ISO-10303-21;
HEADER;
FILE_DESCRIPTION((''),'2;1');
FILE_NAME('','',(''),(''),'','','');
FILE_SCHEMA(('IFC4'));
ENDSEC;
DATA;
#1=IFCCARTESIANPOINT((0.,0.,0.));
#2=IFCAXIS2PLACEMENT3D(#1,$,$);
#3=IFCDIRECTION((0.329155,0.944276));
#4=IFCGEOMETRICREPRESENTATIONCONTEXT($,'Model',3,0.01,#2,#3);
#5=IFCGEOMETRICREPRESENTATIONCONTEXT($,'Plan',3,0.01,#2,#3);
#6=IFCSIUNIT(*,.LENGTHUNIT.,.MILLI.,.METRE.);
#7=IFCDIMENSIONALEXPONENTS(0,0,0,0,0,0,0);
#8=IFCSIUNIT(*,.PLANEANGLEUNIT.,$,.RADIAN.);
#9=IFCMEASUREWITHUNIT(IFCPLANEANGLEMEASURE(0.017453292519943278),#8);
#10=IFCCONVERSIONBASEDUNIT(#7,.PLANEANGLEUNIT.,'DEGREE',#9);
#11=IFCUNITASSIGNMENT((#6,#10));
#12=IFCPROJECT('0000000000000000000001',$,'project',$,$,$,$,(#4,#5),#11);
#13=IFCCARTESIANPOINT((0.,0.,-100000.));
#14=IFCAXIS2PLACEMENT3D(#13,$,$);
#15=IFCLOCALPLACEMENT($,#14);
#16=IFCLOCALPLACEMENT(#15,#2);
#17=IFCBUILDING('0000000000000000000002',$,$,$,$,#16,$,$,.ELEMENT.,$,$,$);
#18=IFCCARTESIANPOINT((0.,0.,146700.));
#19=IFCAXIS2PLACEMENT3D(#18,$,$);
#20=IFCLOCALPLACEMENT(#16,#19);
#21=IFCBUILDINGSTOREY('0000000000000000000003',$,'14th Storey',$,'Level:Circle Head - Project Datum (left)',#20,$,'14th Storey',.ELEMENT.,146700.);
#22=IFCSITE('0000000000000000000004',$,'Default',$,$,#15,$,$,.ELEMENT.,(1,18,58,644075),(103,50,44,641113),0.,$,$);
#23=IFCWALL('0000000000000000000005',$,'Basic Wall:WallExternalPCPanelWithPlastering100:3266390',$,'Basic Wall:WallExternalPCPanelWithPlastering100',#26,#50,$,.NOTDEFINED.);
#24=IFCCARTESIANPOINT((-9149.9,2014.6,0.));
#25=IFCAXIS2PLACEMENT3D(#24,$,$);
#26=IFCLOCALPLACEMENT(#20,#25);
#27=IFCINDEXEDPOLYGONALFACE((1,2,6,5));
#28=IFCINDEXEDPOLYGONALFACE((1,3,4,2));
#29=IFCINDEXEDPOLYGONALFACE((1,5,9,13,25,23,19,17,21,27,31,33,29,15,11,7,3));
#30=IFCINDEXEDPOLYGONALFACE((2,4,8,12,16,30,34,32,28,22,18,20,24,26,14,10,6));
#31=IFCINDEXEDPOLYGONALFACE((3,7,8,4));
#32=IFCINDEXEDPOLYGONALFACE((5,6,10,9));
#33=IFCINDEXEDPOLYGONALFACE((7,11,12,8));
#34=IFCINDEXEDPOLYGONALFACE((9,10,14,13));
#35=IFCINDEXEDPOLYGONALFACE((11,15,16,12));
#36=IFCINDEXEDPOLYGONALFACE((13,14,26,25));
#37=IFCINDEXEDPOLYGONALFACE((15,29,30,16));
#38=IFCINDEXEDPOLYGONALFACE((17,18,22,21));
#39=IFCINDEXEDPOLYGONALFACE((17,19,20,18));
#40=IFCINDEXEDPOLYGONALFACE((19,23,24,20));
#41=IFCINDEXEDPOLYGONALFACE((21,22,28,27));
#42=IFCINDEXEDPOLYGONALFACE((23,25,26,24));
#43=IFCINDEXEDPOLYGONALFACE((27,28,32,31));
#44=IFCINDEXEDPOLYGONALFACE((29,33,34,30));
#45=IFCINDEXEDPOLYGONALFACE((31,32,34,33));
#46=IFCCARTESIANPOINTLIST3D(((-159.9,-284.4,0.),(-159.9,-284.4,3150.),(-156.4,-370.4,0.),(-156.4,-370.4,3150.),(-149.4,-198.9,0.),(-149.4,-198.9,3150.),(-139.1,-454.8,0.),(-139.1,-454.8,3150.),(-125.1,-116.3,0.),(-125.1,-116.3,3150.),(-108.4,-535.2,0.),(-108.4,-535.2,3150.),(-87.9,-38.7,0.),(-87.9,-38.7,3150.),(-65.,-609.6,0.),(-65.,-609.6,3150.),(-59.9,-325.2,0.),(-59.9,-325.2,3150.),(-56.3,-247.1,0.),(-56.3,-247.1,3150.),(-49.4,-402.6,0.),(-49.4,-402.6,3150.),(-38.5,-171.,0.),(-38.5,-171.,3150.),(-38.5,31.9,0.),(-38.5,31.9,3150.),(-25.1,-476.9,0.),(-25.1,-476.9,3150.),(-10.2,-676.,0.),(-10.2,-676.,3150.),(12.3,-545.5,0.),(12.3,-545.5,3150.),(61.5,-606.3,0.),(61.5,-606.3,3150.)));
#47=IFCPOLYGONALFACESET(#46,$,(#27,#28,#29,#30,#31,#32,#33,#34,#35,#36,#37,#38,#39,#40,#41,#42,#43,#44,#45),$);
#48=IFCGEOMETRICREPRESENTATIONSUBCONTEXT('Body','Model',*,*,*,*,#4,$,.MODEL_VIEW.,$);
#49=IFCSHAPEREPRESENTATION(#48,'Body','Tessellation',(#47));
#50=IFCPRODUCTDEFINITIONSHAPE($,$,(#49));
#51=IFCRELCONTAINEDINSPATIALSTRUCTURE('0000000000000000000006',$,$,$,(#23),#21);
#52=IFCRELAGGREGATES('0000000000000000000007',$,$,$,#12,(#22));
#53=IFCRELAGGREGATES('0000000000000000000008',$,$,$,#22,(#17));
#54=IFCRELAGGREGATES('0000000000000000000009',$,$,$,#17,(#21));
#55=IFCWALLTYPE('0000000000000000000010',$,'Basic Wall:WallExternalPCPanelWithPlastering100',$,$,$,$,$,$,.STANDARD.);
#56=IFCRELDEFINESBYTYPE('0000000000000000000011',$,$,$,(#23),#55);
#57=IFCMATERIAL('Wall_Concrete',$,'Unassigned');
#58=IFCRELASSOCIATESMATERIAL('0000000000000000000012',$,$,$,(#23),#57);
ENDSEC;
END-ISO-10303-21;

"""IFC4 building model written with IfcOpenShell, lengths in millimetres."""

from ifc_helpers import new_model, entity, si_unit, converted_unit, direction, frame, origin, place, context, subcontext, project, spatial, line, arc, indexed_curve, outline, extrude, material, type_object, element, save


model = new_model("IFC4")

# Units and contexts
model_context = context("Model", 3, precision=0.01, world=origin(), true_north=direction((0.329155, 0.944276)))
plan_context = context("Plan", 3, precision=0.01, world=origin(), true_north=direction((0.329155, 0.944276)))
body_context = subcontext(model_context, "Body", "Model", "MODEL_VIEW")
ifc_project = project(units=[si_unit("LENGTHUNIT", "METRE", prefix="MILLI"), converted_unit("PLANEANGLEUNIT", "DEGREE", entity("IfcPlaneAngleMeasure", 0.017453292519943278), si_unit("PLANEANGLEUNIT", "RADIAN"), dimensions=[0, 0, 0, 0, 0, 0, 0])], contexts=[model_context, plan_context])

# Site, building, storey
site_placement = place(None, frame((0.0, 0.0, -100000.0)))
site = spatial("IfcSite", under=ifc_project, at=site_placement, Name="Default", CompositionType="ELEMENT", RefLatitude=(1, 18, 58, 644075), RefLongitude=(103, 50, 44, 641113), RefElevation=0.0)
building_placement = place(site_placement, origin())
building = spatial("IfcBuilding", under=site, at=building_placement, CompositionType="ELEMENT")
storey_placement = place(building_placement, frame((0.0, 0.0, 146700.0)))
storey = spatial("IfcBuildingStorey", under=building, at=storey_placement, Name="14th Storey", ObjectType="Level:Circle Head - Project Datum (left)", LongName="14th Storey", CompositionType="ELEMENT", Elevation=146700.0)

# Wall
ifc_material_1 = material(Name="Wall_Concrete", Category="Unassigned")
wall_type_1 = type_object("IfcWallType", Name="Basic Wall:WallExternalPCPanelWithPlastering100", PredefinedType="STANDARD")
wall_1_placement = place(storey_placement, frame((-9149.9, 2014.6, 0.0)))
element("IfcWall", 1, at=wall_1_placement, inside=storey, type_object=wall_type_1, material=ifc_material_1, Name="Basic Wall:WallExternalPCPanelWithPlastering100:3266390", ObjectType="Basic Wall:WallExternalPCPanelWithPlastering100", PredefinedType="NOTDEFINED", context=body_context, shape_type="SweptSolid", body=[
    extrude(outline(indexed_curve([(61.5, -606.3), (-49.4, -402.6), (-38.5, -171.0), (-38.5, 31.9), (-159.9, -327.5), (-10.2, -676.0)], segments=[arc(1, 2, 3), line(3, 4), arc(4, 5, 6), line(6, 1)], self_intersect=False)), origin(), (0.0, 0.0, 1.0), 3150.0),
])

save(model, "model.ifc")
